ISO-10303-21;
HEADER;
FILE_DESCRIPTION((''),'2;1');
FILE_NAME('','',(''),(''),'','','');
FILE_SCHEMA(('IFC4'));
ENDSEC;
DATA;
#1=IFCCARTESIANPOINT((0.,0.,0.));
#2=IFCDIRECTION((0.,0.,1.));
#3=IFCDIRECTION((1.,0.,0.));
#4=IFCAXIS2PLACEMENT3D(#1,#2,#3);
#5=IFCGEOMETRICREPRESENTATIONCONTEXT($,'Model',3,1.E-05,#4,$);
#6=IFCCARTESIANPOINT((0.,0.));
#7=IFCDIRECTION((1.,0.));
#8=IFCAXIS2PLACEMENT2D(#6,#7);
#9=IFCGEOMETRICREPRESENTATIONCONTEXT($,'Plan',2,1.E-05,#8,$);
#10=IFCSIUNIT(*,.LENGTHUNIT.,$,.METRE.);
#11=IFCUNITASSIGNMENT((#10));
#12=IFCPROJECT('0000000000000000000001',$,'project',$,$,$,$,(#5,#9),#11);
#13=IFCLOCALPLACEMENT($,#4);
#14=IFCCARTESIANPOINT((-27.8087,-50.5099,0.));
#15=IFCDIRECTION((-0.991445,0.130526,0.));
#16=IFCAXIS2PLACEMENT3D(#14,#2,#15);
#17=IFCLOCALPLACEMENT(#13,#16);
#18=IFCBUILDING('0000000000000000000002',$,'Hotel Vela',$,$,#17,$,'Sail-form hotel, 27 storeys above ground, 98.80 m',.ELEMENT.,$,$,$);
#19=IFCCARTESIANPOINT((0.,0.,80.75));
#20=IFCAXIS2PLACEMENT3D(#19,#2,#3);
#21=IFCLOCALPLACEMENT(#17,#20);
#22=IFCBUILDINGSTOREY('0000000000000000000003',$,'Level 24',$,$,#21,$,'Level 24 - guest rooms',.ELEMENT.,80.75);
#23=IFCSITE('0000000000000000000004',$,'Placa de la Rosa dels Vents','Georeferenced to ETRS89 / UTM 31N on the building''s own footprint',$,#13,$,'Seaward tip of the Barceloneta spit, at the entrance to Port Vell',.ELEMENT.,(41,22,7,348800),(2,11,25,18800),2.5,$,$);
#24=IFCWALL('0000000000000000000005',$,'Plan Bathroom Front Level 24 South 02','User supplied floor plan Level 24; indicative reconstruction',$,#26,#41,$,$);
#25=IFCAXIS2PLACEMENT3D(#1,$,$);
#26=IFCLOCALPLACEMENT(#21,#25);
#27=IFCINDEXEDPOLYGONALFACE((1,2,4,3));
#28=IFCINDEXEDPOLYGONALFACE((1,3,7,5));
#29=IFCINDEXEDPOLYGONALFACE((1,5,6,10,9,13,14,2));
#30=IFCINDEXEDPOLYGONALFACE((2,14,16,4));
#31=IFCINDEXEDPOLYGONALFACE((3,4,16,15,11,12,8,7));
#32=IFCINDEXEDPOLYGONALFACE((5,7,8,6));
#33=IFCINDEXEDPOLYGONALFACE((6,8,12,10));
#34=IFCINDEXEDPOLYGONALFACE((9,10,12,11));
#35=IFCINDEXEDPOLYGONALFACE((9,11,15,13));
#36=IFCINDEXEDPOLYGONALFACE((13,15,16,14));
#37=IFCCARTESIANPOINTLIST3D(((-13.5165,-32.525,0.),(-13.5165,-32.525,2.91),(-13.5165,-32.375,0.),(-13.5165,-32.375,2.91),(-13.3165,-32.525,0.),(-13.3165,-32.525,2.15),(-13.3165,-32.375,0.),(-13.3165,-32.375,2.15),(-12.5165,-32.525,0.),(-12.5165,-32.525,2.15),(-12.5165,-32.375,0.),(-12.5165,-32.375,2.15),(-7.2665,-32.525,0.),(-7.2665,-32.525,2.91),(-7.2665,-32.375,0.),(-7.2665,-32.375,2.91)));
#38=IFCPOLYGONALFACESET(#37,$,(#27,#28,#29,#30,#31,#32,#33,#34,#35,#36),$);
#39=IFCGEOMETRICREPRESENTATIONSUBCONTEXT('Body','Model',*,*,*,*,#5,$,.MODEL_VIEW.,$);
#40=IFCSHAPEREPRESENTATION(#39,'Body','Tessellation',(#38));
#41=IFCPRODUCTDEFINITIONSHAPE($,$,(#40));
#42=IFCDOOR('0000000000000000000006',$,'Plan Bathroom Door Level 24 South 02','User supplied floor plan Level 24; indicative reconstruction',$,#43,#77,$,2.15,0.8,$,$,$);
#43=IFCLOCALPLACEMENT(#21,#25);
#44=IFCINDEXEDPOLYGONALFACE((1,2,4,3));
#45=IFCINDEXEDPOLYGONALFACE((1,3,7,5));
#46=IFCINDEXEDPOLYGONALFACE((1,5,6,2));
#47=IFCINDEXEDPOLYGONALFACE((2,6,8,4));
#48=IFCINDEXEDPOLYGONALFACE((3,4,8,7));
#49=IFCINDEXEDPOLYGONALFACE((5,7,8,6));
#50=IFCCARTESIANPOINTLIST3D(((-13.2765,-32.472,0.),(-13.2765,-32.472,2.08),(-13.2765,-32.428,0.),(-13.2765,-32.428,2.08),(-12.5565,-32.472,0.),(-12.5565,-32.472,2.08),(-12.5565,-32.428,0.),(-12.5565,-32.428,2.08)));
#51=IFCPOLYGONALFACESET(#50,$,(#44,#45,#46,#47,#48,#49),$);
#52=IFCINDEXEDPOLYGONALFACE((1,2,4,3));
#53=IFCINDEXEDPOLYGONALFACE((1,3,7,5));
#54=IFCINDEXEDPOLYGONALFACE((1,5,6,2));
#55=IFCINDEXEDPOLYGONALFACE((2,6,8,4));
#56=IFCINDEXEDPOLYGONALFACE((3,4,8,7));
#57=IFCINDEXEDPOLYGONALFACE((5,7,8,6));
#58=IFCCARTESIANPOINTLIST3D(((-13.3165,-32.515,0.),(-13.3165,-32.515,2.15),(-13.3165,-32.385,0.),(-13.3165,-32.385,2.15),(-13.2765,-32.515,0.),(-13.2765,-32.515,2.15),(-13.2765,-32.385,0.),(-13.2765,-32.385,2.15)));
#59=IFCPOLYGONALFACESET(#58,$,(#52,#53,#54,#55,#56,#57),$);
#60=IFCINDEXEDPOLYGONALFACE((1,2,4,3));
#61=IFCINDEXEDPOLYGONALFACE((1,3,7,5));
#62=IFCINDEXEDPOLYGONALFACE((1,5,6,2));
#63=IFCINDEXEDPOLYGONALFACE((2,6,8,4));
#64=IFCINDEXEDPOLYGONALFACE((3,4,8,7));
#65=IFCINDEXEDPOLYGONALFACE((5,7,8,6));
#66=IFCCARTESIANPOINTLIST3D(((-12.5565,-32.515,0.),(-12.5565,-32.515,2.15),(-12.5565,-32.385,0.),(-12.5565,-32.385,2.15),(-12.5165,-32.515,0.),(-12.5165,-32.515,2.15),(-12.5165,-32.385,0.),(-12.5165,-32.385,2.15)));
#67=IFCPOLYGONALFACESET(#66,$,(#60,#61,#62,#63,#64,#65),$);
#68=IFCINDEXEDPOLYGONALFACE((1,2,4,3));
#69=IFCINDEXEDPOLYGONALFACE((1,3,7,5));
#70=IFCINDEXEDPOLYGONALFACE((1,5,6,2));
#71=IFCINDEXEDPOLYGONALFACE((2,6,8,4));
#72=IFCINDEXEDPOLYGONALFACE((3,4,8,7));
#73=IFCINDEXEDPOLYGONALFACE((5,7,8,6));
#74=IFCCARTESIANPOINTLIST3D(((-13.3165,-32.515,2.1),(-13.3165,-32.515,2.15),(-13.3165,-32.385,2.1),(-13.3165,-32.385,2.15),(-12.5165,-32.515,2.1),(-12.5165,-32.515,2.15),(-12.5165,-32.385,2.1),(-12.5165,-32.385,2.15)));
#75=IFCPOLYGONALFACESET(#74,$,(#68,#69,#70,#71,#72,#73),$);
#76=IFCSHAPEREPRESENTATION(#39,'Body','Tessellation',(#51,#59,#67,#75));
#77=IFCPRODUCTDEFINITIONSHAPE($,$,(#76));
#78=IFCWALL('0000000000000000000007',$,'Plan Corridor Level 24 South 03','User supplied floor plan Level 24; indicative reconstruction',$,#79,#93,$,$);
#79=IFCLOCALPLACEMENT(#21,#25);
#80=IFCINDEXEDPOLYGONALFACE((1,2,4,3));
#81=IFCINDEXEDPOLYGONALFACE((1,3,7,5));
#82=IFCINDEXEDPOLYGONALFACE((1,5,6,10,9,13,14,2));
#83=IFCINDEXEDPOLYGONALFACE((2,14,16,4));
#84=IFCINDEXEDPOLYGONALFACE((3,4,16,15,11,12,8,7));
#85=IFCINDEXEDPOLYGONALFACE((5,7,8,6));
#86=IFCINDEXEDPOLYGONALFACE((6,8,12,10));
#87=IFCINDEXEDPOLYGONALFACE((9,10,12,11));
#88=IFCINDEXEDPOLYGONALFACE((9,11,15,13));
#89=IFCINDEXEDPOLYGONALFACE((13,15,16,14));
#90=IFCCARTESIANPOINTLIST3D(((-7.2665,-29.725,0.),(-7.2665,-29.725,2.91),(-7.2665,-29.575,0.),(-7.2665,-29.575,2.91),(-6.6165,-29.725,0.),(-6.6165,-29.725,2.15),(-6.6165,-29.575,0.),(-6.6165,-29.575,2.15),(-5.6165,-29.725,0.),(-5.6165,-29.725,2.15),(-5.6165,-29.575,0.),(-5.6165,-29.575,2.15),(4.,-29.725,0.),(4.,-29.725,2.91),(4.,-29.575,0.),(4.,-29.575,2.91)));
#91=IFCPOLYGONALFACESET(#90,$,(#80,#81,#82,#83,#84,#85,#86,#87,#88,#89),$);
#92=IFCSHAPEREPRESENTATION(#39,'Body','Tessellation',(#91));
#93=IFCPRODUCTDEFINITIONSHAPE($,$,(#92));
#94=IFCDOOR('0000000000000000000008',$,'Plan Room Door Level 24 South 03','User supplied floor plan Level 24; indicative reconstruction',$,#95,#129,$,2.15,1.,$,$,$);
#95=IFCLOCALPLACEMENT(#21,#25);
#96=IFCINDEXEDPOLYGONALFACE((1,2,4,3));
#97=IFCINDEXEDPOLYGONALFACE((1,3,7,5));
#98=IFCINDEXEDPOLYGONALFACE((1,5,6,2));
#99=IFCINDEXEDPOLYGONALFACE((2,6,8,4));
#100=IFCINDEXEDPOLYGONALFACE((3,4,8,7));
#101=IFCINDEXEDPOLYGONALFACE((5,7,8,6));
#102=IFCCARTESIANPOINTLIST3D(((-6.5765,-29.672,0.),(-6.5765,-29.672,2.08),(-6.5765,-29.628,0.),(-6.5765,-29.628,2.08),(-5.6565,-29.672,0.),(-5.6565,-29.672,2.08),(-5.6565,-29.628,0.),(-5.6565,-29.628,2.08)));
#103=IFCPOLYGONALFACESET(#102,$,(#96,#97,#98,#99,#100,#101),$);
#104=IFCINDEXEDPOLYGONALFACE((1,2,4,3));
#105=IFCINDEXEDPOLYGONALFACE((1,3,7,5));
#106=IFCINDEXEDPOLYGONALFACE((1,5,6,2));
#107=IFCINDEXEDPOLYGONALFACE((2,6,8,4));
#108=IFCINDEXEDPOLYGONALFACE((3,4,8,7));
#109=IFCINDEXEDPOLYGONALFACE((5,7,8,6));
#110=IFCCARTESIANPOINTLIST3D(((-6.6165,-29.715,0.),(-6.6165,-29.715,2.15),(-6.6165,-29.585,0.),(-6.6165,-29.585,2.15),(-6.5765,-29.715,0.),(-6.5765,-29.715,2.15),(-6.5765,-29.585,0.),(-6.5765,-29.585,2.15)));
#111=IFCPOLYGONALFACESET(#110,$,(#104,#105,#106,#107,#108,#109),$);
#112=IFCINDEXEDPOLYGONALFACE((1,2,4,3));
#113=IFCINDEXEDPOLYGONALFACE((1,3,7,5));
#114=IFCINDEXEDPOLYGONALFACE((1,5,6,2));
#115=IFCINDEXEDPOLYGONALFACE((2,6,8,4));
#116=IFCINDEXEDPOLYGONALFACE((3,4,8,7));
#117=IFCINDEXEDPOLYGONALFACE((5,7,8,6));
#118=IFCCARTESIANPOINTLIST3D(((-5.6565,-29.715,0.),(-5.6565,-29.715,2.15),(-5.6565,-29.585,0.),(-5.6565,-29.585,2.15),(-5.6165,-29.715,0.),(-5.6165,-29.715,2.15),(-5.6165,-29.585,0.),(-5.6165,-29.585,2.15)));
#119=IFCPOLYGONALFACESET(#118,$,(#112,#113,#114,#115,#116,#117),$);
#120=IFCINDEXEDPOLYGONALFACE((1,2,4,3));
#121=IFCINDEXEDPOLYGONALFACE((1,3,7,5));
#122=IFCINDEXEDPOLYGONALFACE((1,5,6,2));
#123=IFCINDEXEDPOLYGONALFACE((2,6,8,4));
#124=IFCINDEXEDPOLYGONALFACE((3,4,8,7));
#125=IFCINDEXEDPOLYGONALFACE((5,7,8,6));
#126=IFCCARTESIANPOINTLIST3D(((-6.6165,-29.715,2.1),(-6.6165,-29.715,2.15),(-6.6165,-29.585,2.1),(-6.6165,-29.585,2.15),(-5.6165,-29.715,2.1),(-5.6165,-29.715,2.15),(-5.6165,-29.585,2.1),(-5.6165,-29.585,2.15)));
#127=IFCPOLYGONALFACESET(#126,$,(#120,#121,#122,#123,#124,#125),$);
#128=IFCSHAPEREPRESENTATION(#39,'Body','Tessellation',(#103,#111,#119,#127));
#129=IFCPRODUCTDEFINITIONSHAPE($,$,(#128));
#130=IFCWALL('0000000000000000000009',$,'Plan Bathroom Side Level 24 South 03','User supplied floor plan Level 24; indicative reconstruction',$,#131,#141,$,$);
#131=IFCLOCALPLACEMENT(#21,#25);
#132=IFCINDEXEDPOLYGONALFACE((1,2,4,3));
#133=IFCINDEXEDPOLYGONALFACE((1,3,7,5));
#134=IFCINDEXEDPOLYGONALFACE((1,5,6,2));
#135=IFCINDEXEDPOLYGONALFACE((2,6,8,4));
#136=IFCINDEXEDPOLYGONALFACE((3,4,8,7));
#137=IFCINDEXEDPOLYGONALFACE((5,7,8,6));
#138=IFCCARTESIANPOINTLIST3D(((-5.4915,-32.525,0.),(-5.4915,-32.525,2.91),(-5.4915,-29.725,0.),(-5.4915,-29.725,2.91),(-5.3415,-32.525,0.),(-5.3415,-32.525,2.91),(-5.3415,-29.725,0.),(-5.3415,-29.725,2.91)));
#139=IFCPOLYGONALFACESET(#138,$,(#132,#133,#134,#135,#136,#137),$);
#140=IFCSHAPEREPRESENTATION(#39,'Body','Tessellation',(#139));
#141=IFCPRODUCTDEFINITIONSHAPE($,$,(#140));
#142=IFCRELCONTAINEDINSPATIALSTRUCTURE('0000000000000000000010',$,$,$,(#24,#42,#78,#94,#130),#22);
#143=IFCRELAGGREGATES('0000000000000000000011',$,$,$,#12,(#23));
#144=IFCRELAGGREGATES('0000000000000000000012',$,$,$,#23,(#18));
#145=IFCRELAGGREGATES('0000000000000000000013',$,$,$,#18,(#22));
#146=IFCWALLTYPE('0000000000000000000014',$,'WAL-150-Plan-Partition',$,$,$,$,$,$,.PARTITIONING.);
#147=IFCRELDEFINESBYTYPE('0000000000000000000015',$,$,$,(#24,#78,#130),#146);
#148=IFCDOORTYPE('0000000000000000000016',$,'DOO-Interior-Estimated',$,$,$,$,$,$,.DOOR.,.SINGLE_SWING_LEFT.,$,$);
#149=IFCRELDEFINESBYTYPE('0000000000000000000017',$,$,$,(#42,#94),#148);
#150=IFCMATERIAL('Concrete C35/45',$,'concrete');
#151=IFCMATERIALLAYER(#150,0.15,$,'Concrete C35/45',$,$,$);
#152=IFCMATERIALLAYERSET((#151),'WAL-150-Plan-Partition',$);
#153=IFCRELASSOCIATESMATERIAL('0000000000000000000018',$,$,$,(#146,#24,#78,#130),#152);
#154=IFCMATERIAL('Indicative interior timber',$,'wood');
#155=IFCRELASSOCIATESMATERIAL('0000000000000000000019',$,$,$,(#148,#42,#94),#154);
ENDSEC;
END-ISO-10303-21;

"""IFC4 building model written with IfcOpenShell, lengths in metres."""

from ifc_helpers import new_model, si_unit, frame, origin_with_axes, origin_2d_with_axis, place, context, subcontext, project, spatial, line, indexed_curve, outline, extrude, material, layer, layer_set, layer_usage, type_object, element, fill, save


model = new_model("IFC4")

# Units and contexts
model_context = context("Model", 3, precision=1e-05, world=origin_with_axes())
plan_context = context("Plan", 2, precision=1e-05, world=origin_2d_with_axis())
body_context = subcontext(model_context, "Body", "Model", "MODEL_VIEW")
ifc_project = project(units=[si_unit("LENGTHUNIT", "METRE")], contexts=[model_context, plan_context])

# Site, building, storey
site_placement = place(None, origin_with_axes())
site = spatial("IfcSite", under=ifc_project, at=site_placement, Name="Placa de la Rosa dels Vents", Description="Georeferenced to ETRS89 / UTM 31N on the building's own footprint", LongName="Seaward tip of the Barceloneta spit, at the entrance to Port Vell", CompositionType="ELEMENT", RefLatitude=(41, 22, 7, 348800), RefLongitude=(2, 11, 25, 18800), RefElevation=2.5)
building_placement = place(site_placement, frame((-27.8087, -50.5099, 0.0), z_axis=(0.0, 0.0, 1.0), x_axis=(-0.991445, 0.130526, 0.0)))
building = spatial("IfcBuilding", under=site, at=building_placement, Name="Hotel Vela", LongName="Sail-form hotel, 27 storeys above ground, 98.80 m", CompositionType="ELEMENT")
storey_placement = place(building_placement, frame((0.0, 0.0, 80.75), z_axis=(0.0, 0.0, 1.0), x_axis=(1.0, 0.0, 0.0)))
storey = spatial("IfcBuildingStorey", under=building, at=storey_placement, Name="Level 24", LongName="Level 24 - guest rooms", CompositionType="ELEMENT", Elevation=80.75)

# Shared definitions
ifc_material_1 = material(Name="Concrete C35/45", Category="concrete")

# Shared definitions
ifc_layer_1 = layer(ifc_material_1, 0.15, Name="Concrete C35/45")
ifc_layer_set_1 = layer_set([ifc_layer_1], Name="WAL-150-Plan-Partition")
wall_type = type_object("IfcWallType", Name="WAL-150-Plan-Partition", PredefinedType="PARTITIONING", material=ifc_layer_set_1)
ifc_material_2 = material(Name="Indicative interior timber", Category="wood")
door_type = type_object("IfcDoorType", Name="DOO-Interior-Estimated", OperationType="SINGLE_SWING_LEFT", PredefinedType="DOOR", material=ifc_material_2)

# Walls, openings, doors
ifc_layer_usage_1 = layer_usage(ifc_layer_set_1, "AXIS2", "POSITIVE", 0.0)
wall_1_placement = place(storey_placement, frame((-13.5165, -32.525, 0.0), z_axis=(0.0, 0.0, 1.0), x_axis=(1.0, 0.0, 0.0)))
wall_1 = element("IfcWall", 1, at=wall_1_placement, inside=storey, type_object=wall_type, material=ifc_layer_usage_1, Name="Plan Bathroom Front Level 24 South 02", Description="User supplied floor plan Level 24; indicative reconstruction", context=body_context, shape_type="SweptSolid", body=[
    extrude(outline(indexed_curve([(0.0, 0.0), (6.25, 0.0), (6.25, 0.15), (0.0, 0.15)], segments=[line(1, 2, 3, 4, 1)])), origin_with_axes(), (0.0, 0.0, 1.0), 2.91),
])
opening_1_placement = place(wall_1_placement, frame((0.2, -0.085, 0.0), z_axis=(0.0, 0.0, 1.0), x_axis=(1.0, 0.0, 0.0)))
opening_1 = element("IfcOpeningElement", 2, at=opening_1_placement, cuts=wall_1, PredefinedType="OPENING", context=body_context, shape_type="SweptSolid", body=[
    extrude(outline(indexed_curve([(0.0, 0.0), (0.8, 0.0), (0.8, 0.32), (0.0, 0.32)], segments=[line(1, 2, 3, 4, 1)])), origin_with_axes(), (0.0, 0.0, 1.0), 2.15),
])
door_1_placement = place(storey_placement, frame((0.0, 0.0, -80.75), z_axis=(0.0, 0.0, 1.0), x_axis=(1.0, 0.0, 0.0)))
door_1 = element("IfcDoor", 3, at=door_1_placement, inside=storey, type_object=door_type, material=ifc_material_2, Name="Plan Bathroom Door Level 24 South 02", Description="User supplied floor plan Level 24; indicative reconstruction", OverallHeight=2.15, OverallWidth=0.8, context=body_context, shape_type="SweptSolid", body=[
    extrude(outline(indexed_curve([(0.0, 0.0), (0.72, 0.0), (0.72, 0.044), (0.0, 0.044)], segments=[line(1, 2, 3, 4, 1)])), frame((-13.2765, -32.472, 80.75), z_axis=(0.0, 0.0, 1.0), x_axis=(1.0, 0.0, 0.0)), (0.0, 0.0, 1.0), 2.08),
    extrude(outline(indexed_curve([(0.0, 0.0), (0.04, 0.0), (0.04, 0.13), (0.0, 0.13)], segments=[line(1, 2, 3, 4, 1)])), frame((-13.3165, -32.515, 80.75), z_axis=(0.0, 0.0, 1.0), x_axis=(1.0, 0.0, 0.0)), (0.0, 0.0, 1.0), 2.15),
    extrude(outline(indexed_curve([(0.0, 0.0), (0.04, 0.0), (0.04, 0.13), (0.0, 0.13)], segments=[line(1, 2, 3, 4, 1)])), frame((-12.5565, -32.515, 80.75), z_axis=(0.0, 0.0, 1.0), x_axis=(1.0, 0.0, 0.0)), (0.0, 0.0, 1.0), 2.15),
    extrude(outline(indexed_curve([(0.0, 0.0), (0.8, 0.0), (0.8, 0.13), (0.0, 0.13)], segments=[line(1, 2, 3, 4, 1)])), frame((-13.3165, -32.515, 82.85), z_axis=(0.0, 0.0, 1.0), x_axis=(1.0, 0.0, 0.0)), (0.0, 0.0, 1.0), 0.05),
])
fill(opening_1, door_1)
ifc_layer_usage_2 = layer_usage(ifc_layer_set_1, "AXIS2", "POSITIVE", 0.0)
wall_2_placement = place(storey_placement, frame((-7.2665, -29.725, 0.0), z_axis=(0.0, 0.0, 1.0), x_axis=(1.0, 0.0, 0.0)))
wall_2 = element("IfcWall", 4, at=wall_2_placement, inside=storey, type_object=wall_type, material=ifc_layer_usage_2, Name="Plan Corridor Level 24 South 03", Description="User supplied floor plan Level 24; indicative reconstruction", context=body_context, shape_type="SweptSolid", body=[
    extrude(outline(indexed_curve([(0.0, 0.0), (11.2665, 0.0), (11.2665, 0.15), (0.0, 0.15)], segments=[line(1, 2, 3, 4, 1)])), origin_with_axes(), (0.0, 0.0, 1.0), 2.91),
])
opening_2_placement = place(wall_2_placement, frame((0.65, -0.085, 0.0), z_axis=(0.0, 0.0, 1.0), x_axis=(1.0, 0.0, 0.0)))
opening_2 = element("IfcOpeningElement", 5, at=opening_2_placement, cuts=wall_2, PredefinedType="OPENING", context=body_context, shape_type="SweptSolid", body=[
    extrude(outline(indexed_curve([(0.0, 0.0), (1.0, 0.0), (1.0, 0.32), (0.0, 0.32)], segments=[line(1, 2, 3, 4, 1)])), origin_with_axes(), (0.0, 0.0, 1.0), 2.15),
])
door_2_placement = place(storey_placement, frame((0.0, 0.0, -80.75), z_axis=(0.0, 0.0, 1.0), x_axis=(1.0, 0.0, 0.0)))
door_2 = element("IfcDoor", 6, at=door_2_placement, inside=storey, type_object=door_type, material=ifc_material_2, Name="Plan Room Door Level 24 South 03", Description="User supplied floor plan Level 24; indicative reconstruction", OverallHeight=2.15, OverallWidth=1.0, context=body_context, shape_type="SweptSolid", body=[
    extrude(outline(indexed_curve([(0.0, 0.0), (0.92, 0.0), (0.92, 0.044), (0.0, 0.044)], segments=[line(1, 2, 3, 4, 1)])), frame((-6.5765, -29.672, 80.75), z_axis=(0.0, 0.0, 1.0), x_axis=(1.0, 0.0, 0.0)), (0.0, 0.0, 1.0), 2.08),
    extrude(outline(indexed_curve([(0.0, 0.0), (0.04, 0.0), (0.04, 0.13), (0.0, 0.13)], segments=[line(1, 2, 3, 4, 1)])), frame((-6.6165, -29.715, 80.75), z_axis=(0.0, 0.0, 1.0), x_axis=(1.0, 0.0, 0.0)), (0.0, 0.0, 1.0), 2.15),
    extrude(outline(indexed_curve([(0.0, 0.0), (0.04, 0.0), (0.04, 0.13), (0.0, 0.13)], segments=[line(1, 2, 3, 4, 1)])), frame((-5.6565, -29.715, 80.75), z_axis=(0.0, 0.0, 1.0), x_axis=(1.0, 0.0, 0.0)), (0.0, 0.0, 1.0), 2.15),
    extrude(outline(indexed_curve([(0.0, 0.0), (1.0, 0.0), (1.0, 0.13), (0.0, 0.13)], segments=[line(1, 2, 3, 4, 1)])), frame((-6.6165, -29.715, 82.85), z_axis=(0.0, 0.0, 1.0), x_axis=(1.0, 0.0, 0.0)), (0.0, 0.0, 1.0), 0.05),
])
fill(opening_2, door_2)

# Wall
ifc_layer_usage_3 = layer_usage(ifc_layer_set_1, "AXIS2", "POSITIVE", 0.0)
wall_3_placement = place(storey_placement, frame((-5.4915, -32.525, 0.0), z_axis=(0.0, 0.0, 1.0), x_axis=(1.0, 0.0, 0.0)))
element("IfcWall", 7, at=wall_3_placement, inside=storey, type_object=wall_type, material=ifc_layer_usage_3, Name="Plan Bathroom Side Level 24 South 03", Description="User supplied floor plan Level 24; indicative reconstruction", context=body_context, shape_type="SweptSolid", body=[
    extrude(outline(indexed_curve([(0.0, 0.0), (0.15, 0.0), (0.15, 2.8), (0.0, 2.8)], segments=[line(1, 2, 3, 4, 1)])), origin_with_axes(), (0.0, 0.0, 1.0), 2.91),
])

save(model, "model.ifc")
